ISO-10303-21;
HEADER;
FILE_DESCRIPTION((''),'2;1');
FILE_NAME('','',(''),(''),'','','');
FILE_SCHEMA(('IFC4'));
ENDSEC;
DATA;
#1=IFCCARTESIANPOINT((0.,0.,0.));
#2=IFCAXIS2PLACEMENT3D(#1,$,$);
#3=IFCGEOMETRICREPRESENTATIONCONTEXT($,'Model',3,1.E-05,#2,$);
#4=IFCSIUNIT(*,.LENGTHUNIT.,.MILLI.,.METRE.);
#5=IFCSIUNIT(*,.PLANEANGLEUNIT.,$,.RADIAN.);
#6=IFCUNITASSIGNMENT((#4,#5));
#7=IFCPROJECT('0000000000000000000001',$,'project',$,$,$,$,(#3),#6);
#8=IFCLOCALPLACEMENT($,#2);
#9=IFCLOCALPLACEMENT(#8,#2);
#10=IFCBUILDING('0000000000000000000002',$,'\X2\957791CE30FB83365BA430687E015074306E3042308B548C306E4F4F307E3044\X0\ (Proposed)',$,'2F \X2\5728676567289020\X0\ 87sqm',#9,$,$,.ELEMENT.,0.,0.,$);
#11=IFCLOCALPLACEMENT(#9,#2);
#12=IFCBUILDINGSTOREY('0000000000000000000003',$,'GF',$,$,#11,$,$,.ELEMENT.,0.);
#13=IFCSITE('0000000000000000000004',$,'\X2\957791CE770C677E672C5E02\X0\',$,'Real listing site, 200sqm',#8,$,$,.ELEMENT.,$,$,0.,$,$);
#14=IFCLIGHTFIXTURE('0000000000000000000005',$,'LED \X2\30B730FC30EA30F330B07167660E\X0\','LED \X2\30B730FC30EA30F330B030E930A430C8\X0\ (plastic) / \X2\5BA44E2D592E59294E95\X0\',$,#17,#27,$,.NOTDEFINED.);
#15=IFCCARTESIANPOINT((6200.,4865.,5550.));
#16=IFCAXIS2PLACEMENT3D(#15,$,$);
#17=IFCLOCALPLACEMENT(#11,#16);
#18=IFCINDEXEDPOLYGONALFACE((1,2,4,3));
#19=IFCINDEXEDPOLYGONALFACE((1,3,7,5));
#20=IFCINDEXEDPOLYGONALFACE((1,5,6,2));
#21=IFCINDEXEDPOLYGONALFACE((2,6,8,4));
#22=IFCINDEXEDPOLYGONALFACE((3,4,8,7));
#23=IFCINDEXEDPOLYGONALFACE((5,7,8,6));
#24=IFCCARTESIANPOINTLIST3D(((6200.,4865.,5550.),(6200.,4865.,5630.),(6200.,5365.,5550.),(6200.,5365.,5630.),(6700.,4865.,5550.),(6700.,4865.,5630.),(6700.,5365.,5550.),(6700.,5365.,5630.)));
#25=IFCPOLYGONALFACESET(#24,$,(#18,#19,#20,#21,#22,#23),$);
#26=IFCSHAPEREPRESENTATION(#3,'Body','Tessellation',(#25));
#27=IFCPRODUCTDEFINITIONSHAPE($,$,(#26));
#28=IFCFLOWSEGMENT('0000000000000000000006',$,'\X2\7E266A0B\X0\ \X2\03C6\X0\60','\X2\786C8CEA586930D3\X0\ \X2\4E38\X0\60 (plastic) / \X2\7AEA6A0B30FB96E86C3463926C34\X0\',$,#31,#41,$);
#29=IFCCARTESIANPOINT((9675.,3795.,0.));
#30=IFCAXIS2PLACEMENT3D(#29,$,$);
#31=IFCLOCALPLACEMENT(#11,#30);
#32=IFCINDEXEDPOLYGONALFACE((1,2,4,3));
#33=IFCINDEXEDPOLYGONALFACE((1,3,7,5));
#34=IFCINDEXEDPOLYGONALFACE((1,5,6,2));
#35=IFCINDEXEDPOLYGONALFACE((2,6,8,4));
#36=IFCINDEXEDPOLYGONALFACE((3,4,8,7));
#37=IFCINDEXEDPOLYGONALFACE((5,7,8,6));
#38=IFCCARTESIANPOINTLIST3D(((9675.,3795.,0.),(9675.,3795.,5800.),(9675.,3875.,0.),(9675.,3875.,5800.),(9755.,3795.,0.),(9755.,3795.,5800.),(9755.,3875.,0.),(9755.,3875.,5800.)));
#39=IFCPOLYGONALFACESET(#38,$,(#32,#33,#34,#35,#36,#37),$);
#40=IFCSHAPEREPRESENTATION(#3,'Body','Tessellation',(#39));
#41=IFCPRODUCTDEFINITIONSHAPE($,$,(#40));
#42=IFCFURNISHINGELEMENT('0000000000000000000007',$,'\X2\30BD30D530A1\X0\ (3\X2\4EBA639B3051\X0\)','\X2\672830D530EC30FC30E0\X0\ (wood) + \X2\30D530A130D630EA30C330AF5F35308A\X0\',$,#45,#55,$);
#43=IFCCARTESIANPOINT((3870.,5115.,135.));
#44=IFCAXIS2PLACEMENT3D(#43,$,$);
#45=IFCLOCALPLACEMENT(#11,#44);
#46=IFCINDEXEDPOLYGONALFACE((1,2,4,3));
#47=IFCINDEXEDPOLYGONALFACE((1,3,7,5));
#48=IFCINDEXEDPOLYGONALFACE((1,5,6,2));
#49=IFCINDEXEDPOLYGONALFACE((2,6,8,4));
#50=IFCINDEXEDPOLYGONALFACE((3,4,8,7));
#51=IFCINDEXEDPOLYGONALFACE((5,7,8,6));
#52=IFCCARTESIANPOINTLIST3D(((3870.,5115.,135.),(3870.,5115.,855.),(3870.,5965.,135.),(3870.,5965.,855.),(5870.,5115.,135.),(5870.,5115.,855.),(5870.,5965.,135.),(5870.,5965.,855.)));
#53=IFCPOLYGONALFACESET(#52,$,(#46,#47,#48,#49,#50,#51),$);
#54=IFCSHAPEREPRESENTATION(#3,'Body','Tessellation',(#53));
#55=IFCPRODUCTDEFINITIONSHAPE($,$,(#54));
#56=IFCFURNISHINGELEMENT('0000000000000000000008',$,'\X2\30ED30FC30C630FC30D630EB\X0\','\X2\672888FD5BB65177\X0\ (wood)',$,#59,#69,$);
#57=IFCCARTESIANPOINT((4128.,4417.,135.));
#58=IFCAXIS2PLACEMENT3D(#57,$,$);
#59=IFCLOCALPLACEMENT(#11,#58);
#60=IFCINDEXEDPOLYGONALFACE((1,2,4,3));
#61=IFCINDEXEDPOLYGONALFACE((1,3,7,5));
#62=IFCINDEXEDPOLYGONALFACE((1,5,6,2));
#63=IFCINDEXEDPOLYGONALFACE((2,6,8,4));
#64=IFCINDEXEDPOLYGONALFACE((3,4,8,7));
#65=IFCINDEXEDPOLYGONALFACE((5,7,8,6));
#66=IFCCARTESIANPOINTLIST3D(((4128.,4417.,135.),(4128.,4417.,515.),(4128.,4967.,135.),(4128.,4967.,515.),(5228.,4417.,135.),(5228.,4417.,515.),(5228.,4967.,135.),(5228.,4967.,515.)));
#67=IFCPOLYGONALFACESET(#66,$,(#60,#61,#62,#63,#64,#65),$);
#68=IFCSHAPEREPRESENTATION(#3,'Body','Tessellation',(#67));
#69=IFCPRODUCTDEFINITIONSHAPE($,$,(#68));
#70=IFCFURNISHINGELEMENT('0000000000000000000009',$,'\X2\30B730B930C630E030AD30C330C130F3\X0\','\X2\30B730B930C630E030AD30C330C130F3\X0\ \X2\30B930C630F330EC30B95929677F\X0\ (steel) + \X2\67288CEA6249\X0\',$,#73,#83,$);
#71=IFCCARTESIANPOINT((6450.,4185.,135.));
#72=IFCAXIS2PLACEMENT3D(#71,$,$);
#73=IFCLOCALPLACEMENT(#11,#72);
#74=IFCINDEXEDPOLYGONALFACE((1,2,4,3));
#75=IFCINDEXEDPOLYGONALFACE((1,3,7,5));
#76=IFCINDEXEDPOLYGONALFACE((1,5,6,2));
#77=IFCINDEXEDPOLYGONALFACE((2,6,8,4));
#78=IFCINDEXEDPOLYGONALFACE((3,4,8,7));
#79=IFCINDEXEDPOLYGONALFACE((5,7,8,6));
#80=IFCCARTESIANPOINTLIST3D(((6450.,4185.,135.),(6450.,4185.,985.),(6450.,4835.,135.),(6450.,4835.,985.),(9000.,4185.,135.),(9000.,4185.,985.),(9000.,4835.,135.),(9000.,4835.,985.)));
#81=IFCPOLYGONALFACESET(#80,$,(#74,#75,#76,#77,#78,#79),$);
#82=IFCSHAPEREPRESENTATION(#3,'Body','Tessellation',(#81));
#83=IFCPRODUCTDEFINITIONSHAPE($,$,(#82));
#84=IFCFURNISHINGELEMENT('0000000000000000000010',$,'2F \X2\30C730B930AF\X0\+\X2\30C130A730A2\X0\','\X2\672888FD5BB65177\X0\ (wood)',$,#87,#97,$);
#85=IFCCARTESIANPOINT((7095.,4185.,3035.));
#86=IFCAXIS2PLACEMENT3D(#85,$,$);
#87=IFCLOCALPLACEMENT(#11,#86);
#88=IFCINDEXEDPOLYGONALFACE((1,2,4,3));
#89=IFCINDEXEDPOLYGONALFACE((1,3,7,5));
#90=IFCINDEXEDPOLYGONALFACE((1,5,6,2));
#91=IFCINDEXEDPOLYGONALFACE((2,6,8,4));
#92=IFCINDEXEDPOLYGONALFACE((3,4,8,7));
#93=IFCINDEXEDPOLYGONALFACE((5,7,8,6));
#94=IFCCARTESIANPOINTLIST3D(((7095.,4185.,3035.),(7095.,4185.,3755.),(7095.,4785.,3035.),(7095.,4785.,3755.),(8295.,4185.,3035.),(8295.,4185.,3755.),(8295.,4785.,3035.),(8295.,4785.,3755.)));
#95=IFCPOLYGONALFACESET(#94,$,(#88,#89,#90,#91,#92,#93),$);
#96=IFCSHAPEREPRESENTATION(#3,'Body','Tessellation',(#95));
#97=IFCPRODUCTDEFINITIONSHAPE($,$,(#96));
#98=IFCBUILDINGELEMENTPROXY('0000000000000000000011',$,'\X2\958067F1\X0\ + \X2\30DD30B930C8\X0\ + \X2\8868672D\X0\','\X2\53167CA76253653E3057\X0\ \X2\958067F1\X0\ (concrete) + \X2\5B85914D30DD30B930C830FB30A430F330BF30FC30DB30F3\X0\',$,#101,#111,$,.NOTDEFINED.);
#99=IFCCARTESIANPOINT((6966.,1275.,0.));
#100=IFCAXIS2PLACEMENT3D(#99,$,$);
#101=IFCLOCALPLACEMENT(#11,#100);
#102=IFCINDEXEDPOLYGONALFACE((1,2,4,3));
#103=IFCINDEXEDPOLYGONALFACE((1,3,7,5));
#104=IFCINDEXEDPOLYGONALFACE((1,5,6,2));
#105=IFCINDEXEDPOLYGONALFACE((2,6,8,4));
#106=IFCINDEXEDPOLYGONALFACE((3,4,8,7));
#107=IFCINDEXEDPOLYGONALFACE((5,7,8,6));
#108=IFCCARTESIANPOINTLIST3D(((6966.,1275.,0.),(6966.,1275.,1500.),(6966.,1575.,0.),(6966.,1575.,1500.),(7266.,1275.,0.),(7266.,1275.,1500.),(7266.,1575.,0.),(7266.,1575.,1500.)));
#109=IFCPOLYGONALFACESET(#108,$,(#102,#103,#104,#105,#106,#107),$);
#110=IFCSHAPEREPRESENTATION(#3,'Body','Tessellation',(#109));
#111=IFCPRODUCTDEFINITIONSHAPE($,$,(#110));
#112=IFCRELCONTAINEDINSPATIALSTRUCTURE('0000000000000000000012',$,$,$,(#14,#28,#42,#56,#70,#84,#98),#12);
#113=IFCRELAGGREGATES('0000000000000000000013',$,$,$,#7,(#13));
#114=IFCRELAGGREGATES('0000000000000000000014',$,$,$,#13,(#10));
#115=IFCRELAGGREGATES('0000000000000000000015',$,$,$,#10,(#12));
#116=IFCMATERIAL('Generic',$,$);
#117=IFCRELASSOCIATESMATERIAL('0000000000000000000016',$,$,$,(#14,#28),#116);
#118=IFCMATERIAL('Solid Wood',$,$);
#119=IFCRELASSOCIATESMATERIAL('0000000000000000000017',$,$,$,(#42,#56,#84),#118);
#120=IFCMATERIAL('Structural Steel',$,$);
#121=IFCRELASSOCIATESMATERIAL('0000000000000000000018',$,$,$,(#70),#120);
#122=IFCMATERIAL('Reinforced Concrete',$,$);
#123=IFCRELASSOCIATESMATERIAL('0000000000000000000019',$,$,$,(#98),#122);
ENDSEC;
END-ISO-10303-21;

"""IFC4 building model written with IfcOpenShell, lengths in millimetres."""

from ifc_helpers import new_model, si_unit, frame, frame_2d, origin, place, context, project, spatial, rectangle, extrude, material, element, save


model = new_model("IFC4")

# Units and contexts
model_context = context("Model", 3, precision=1e-05, world=origin())
ifc_project = project(units=[si_unit("LENGTHUNIT", "METRE", prefix="MILLI"), si_unit("PLANEANGLEUNIT", "RADIAN")], contexts=[model_context])

# Site, building, storey
site_placement = place(None, origin())
site = spatial("IfcSite", under=ifc_project, at=site_placement, Name="長野県松本市", ObjectType="Real listing site, 200sqm", CompositionType="ELEMENT", RefElevation=0.0)
building_placement = place(site_placement, origin())
building = spatial("IfcBuilding", under=site, at=building_placement, Name="長野・茶室と縁側のある和の住まい (Proposed)", ObjectType="2F 在来木造 87sqm", CompositionType="ELEMENT", ElevationOfRefHeight=0.0, ElevationOfTerrain=0.0)
storey_placement = place(building_placement, origin())
storey = spatial("IfcBuildingStorey", under=building, at=storey_placement, Name="GF", CompositionType="ELEMENT", Elevation=0.0)

# Shared definitions
ifc_material_1 = material(Name="Solid Wood")

# Shared definitions
ifc_material_2 = material(Name="Reinforced Concrete")

# Shared definitions
ifc_material_3 = material(Name="Structural Steel")

# Shared definitions
ifc_material_4 = material(Name="Generic")

# Light fixture
light_fixture_1_placement = place(storey_placement, frame((6200.0, 4865.0, 5550.0)))
element("IfcLightFixture", 1, at=light_fixture_1_placement, inside=storey, material=ifc_material_4, Name="LED シーリング照明", Description="LED シーリングライト (plastic) / 室中央天井", PredefinedType="NOTDEFINED", context=model_context, shape_type="SweptSolid", body=[
    extrude(rectangle(XDim=500.0, YDim=500.0, at=frame_2d((250.0, 250.0))), frame((6200.0, 4865.0, 5550.0)), (0.0, 0.0, 1.0), 80.0),
])

# Flow segment
flow_segment_placement = place(storey_placement, frame((9675.0, 3795.0, 0.0)))
element("IfcFlowSegment", 2, at=flow_segment_placement, inside=storey, material=ifc_material_4, Name="縦樋 φ60", Description="硬質塩ビ 丸60 (plastic) / 竪樋・雨水排水", context=model_context, shape_type="SweptSolid", body=[
    extrude(rectangle(XDim=80.0, YDim=80.0, at=frame_2d((40.0, 40.0))), frame((9675.0, 3795.0, 0.0)), (0.0, 0.0, 1.0), 5800.0),
])

# Furnishing elements
furnishing_1_placement = place(storey_placement, frame((3870.0, 5115.0, 135.0)))
element("IfcFurnishingElement", 3, at=furnishing_1_placement, inside=storey, material=ifc_material_1, Name="ソファ (3人掛け)", Description="木フレーム (wood) + ファブリック張り", context=model_context, shape_type="SweptSolid", body=[
    extrude(rectangle(XDim=2000.0, YDim=850.0, at=frame_2d((1000.0, 425.0))), frame((3870.0, 5115.0, 135.0)), (0.0, 0.0, 1.0), 720.0),
])
furnishing_2_placement = place(storey_placement, frame((4128.0, 4417.0, 135.0)))
element("IfcFurnishingElement", 4, at=furnishing_2_placement, inside=storey, material=ifc_material_1, Name="ローテーブル", Description="木製家具 (wood)", context=model_context, shape_type="SweptSolid", body=[
    extrude(rectangle(XDim=1100.0, YDim=550.0, at=frame_2d((550.0, 275.0))), frame((4128.0, 4417.0, 135.0)), (0.0, 0.0, 1.0), 380.0),
])
furnishing_3_placement = place(storey_placement, frame((6450.0, 4185.0, 135.0)))
element("IfcFurnishingElement", 5, at=furnishing_3_placement, inside=storey, material=ifc_material_3, Name="システムキッチン", Description="システムキッチン ステンレス天板 (steel) + 木質扉", context=model_context, shape_type="SweptSolid", body=[
    extrude(rectangle(XDim=2550.0, YDim=650.0, at=frame_2d((1275.0, 325.0))), frame((6450.0, 4185.0, 135.0)), (0.0, 0.0, 1.0), 850.0),
])
furnishing_4_placement = place(storey_placement, frame((7095.0, 4185.0, 3035.0)))
element("IfcFurnishingElement", 6, at=furnishing_4_placement, inside=storey, material=ifc_material_1, Name="2F デスク+チェア", Description="木製家具 (wood)", context=model_context, shape_type="SweptSolid", body=[
    extrude(rectangle(XDim=1200.0, YDim=600.0, at=frame_2d((600.0, 300.0))), frame((7095.0, 4185.0, 3035.0)), (0.0, 0.0, 1.0), 720.0),
])

# Building element proxy
proxy_placement = place(storey_placement, frame((6966.0, 1275.0, 0.0)))
element("IfcBuildingElementProxy", 7, at=proxy_placement, inside=storey, material=ifc_material_2, Name="門柱 + ポスト + 表札", Description="化粧打放し 門柱 (concrete) + 宅配ポスト・インターホン", PredefinedType="NOTDEFINED", context=model_context, shape_type="SweptSolid", body=[
    extrude(rectangle(XDim=300.0, YDim=300.0, at=frame_2d((150.0, 150.0))), frame((6966.0, 1275.0, 0.0)), (0.0, 0.0, 1.0), 1500.0),
])

save(model, "model.ifc")
